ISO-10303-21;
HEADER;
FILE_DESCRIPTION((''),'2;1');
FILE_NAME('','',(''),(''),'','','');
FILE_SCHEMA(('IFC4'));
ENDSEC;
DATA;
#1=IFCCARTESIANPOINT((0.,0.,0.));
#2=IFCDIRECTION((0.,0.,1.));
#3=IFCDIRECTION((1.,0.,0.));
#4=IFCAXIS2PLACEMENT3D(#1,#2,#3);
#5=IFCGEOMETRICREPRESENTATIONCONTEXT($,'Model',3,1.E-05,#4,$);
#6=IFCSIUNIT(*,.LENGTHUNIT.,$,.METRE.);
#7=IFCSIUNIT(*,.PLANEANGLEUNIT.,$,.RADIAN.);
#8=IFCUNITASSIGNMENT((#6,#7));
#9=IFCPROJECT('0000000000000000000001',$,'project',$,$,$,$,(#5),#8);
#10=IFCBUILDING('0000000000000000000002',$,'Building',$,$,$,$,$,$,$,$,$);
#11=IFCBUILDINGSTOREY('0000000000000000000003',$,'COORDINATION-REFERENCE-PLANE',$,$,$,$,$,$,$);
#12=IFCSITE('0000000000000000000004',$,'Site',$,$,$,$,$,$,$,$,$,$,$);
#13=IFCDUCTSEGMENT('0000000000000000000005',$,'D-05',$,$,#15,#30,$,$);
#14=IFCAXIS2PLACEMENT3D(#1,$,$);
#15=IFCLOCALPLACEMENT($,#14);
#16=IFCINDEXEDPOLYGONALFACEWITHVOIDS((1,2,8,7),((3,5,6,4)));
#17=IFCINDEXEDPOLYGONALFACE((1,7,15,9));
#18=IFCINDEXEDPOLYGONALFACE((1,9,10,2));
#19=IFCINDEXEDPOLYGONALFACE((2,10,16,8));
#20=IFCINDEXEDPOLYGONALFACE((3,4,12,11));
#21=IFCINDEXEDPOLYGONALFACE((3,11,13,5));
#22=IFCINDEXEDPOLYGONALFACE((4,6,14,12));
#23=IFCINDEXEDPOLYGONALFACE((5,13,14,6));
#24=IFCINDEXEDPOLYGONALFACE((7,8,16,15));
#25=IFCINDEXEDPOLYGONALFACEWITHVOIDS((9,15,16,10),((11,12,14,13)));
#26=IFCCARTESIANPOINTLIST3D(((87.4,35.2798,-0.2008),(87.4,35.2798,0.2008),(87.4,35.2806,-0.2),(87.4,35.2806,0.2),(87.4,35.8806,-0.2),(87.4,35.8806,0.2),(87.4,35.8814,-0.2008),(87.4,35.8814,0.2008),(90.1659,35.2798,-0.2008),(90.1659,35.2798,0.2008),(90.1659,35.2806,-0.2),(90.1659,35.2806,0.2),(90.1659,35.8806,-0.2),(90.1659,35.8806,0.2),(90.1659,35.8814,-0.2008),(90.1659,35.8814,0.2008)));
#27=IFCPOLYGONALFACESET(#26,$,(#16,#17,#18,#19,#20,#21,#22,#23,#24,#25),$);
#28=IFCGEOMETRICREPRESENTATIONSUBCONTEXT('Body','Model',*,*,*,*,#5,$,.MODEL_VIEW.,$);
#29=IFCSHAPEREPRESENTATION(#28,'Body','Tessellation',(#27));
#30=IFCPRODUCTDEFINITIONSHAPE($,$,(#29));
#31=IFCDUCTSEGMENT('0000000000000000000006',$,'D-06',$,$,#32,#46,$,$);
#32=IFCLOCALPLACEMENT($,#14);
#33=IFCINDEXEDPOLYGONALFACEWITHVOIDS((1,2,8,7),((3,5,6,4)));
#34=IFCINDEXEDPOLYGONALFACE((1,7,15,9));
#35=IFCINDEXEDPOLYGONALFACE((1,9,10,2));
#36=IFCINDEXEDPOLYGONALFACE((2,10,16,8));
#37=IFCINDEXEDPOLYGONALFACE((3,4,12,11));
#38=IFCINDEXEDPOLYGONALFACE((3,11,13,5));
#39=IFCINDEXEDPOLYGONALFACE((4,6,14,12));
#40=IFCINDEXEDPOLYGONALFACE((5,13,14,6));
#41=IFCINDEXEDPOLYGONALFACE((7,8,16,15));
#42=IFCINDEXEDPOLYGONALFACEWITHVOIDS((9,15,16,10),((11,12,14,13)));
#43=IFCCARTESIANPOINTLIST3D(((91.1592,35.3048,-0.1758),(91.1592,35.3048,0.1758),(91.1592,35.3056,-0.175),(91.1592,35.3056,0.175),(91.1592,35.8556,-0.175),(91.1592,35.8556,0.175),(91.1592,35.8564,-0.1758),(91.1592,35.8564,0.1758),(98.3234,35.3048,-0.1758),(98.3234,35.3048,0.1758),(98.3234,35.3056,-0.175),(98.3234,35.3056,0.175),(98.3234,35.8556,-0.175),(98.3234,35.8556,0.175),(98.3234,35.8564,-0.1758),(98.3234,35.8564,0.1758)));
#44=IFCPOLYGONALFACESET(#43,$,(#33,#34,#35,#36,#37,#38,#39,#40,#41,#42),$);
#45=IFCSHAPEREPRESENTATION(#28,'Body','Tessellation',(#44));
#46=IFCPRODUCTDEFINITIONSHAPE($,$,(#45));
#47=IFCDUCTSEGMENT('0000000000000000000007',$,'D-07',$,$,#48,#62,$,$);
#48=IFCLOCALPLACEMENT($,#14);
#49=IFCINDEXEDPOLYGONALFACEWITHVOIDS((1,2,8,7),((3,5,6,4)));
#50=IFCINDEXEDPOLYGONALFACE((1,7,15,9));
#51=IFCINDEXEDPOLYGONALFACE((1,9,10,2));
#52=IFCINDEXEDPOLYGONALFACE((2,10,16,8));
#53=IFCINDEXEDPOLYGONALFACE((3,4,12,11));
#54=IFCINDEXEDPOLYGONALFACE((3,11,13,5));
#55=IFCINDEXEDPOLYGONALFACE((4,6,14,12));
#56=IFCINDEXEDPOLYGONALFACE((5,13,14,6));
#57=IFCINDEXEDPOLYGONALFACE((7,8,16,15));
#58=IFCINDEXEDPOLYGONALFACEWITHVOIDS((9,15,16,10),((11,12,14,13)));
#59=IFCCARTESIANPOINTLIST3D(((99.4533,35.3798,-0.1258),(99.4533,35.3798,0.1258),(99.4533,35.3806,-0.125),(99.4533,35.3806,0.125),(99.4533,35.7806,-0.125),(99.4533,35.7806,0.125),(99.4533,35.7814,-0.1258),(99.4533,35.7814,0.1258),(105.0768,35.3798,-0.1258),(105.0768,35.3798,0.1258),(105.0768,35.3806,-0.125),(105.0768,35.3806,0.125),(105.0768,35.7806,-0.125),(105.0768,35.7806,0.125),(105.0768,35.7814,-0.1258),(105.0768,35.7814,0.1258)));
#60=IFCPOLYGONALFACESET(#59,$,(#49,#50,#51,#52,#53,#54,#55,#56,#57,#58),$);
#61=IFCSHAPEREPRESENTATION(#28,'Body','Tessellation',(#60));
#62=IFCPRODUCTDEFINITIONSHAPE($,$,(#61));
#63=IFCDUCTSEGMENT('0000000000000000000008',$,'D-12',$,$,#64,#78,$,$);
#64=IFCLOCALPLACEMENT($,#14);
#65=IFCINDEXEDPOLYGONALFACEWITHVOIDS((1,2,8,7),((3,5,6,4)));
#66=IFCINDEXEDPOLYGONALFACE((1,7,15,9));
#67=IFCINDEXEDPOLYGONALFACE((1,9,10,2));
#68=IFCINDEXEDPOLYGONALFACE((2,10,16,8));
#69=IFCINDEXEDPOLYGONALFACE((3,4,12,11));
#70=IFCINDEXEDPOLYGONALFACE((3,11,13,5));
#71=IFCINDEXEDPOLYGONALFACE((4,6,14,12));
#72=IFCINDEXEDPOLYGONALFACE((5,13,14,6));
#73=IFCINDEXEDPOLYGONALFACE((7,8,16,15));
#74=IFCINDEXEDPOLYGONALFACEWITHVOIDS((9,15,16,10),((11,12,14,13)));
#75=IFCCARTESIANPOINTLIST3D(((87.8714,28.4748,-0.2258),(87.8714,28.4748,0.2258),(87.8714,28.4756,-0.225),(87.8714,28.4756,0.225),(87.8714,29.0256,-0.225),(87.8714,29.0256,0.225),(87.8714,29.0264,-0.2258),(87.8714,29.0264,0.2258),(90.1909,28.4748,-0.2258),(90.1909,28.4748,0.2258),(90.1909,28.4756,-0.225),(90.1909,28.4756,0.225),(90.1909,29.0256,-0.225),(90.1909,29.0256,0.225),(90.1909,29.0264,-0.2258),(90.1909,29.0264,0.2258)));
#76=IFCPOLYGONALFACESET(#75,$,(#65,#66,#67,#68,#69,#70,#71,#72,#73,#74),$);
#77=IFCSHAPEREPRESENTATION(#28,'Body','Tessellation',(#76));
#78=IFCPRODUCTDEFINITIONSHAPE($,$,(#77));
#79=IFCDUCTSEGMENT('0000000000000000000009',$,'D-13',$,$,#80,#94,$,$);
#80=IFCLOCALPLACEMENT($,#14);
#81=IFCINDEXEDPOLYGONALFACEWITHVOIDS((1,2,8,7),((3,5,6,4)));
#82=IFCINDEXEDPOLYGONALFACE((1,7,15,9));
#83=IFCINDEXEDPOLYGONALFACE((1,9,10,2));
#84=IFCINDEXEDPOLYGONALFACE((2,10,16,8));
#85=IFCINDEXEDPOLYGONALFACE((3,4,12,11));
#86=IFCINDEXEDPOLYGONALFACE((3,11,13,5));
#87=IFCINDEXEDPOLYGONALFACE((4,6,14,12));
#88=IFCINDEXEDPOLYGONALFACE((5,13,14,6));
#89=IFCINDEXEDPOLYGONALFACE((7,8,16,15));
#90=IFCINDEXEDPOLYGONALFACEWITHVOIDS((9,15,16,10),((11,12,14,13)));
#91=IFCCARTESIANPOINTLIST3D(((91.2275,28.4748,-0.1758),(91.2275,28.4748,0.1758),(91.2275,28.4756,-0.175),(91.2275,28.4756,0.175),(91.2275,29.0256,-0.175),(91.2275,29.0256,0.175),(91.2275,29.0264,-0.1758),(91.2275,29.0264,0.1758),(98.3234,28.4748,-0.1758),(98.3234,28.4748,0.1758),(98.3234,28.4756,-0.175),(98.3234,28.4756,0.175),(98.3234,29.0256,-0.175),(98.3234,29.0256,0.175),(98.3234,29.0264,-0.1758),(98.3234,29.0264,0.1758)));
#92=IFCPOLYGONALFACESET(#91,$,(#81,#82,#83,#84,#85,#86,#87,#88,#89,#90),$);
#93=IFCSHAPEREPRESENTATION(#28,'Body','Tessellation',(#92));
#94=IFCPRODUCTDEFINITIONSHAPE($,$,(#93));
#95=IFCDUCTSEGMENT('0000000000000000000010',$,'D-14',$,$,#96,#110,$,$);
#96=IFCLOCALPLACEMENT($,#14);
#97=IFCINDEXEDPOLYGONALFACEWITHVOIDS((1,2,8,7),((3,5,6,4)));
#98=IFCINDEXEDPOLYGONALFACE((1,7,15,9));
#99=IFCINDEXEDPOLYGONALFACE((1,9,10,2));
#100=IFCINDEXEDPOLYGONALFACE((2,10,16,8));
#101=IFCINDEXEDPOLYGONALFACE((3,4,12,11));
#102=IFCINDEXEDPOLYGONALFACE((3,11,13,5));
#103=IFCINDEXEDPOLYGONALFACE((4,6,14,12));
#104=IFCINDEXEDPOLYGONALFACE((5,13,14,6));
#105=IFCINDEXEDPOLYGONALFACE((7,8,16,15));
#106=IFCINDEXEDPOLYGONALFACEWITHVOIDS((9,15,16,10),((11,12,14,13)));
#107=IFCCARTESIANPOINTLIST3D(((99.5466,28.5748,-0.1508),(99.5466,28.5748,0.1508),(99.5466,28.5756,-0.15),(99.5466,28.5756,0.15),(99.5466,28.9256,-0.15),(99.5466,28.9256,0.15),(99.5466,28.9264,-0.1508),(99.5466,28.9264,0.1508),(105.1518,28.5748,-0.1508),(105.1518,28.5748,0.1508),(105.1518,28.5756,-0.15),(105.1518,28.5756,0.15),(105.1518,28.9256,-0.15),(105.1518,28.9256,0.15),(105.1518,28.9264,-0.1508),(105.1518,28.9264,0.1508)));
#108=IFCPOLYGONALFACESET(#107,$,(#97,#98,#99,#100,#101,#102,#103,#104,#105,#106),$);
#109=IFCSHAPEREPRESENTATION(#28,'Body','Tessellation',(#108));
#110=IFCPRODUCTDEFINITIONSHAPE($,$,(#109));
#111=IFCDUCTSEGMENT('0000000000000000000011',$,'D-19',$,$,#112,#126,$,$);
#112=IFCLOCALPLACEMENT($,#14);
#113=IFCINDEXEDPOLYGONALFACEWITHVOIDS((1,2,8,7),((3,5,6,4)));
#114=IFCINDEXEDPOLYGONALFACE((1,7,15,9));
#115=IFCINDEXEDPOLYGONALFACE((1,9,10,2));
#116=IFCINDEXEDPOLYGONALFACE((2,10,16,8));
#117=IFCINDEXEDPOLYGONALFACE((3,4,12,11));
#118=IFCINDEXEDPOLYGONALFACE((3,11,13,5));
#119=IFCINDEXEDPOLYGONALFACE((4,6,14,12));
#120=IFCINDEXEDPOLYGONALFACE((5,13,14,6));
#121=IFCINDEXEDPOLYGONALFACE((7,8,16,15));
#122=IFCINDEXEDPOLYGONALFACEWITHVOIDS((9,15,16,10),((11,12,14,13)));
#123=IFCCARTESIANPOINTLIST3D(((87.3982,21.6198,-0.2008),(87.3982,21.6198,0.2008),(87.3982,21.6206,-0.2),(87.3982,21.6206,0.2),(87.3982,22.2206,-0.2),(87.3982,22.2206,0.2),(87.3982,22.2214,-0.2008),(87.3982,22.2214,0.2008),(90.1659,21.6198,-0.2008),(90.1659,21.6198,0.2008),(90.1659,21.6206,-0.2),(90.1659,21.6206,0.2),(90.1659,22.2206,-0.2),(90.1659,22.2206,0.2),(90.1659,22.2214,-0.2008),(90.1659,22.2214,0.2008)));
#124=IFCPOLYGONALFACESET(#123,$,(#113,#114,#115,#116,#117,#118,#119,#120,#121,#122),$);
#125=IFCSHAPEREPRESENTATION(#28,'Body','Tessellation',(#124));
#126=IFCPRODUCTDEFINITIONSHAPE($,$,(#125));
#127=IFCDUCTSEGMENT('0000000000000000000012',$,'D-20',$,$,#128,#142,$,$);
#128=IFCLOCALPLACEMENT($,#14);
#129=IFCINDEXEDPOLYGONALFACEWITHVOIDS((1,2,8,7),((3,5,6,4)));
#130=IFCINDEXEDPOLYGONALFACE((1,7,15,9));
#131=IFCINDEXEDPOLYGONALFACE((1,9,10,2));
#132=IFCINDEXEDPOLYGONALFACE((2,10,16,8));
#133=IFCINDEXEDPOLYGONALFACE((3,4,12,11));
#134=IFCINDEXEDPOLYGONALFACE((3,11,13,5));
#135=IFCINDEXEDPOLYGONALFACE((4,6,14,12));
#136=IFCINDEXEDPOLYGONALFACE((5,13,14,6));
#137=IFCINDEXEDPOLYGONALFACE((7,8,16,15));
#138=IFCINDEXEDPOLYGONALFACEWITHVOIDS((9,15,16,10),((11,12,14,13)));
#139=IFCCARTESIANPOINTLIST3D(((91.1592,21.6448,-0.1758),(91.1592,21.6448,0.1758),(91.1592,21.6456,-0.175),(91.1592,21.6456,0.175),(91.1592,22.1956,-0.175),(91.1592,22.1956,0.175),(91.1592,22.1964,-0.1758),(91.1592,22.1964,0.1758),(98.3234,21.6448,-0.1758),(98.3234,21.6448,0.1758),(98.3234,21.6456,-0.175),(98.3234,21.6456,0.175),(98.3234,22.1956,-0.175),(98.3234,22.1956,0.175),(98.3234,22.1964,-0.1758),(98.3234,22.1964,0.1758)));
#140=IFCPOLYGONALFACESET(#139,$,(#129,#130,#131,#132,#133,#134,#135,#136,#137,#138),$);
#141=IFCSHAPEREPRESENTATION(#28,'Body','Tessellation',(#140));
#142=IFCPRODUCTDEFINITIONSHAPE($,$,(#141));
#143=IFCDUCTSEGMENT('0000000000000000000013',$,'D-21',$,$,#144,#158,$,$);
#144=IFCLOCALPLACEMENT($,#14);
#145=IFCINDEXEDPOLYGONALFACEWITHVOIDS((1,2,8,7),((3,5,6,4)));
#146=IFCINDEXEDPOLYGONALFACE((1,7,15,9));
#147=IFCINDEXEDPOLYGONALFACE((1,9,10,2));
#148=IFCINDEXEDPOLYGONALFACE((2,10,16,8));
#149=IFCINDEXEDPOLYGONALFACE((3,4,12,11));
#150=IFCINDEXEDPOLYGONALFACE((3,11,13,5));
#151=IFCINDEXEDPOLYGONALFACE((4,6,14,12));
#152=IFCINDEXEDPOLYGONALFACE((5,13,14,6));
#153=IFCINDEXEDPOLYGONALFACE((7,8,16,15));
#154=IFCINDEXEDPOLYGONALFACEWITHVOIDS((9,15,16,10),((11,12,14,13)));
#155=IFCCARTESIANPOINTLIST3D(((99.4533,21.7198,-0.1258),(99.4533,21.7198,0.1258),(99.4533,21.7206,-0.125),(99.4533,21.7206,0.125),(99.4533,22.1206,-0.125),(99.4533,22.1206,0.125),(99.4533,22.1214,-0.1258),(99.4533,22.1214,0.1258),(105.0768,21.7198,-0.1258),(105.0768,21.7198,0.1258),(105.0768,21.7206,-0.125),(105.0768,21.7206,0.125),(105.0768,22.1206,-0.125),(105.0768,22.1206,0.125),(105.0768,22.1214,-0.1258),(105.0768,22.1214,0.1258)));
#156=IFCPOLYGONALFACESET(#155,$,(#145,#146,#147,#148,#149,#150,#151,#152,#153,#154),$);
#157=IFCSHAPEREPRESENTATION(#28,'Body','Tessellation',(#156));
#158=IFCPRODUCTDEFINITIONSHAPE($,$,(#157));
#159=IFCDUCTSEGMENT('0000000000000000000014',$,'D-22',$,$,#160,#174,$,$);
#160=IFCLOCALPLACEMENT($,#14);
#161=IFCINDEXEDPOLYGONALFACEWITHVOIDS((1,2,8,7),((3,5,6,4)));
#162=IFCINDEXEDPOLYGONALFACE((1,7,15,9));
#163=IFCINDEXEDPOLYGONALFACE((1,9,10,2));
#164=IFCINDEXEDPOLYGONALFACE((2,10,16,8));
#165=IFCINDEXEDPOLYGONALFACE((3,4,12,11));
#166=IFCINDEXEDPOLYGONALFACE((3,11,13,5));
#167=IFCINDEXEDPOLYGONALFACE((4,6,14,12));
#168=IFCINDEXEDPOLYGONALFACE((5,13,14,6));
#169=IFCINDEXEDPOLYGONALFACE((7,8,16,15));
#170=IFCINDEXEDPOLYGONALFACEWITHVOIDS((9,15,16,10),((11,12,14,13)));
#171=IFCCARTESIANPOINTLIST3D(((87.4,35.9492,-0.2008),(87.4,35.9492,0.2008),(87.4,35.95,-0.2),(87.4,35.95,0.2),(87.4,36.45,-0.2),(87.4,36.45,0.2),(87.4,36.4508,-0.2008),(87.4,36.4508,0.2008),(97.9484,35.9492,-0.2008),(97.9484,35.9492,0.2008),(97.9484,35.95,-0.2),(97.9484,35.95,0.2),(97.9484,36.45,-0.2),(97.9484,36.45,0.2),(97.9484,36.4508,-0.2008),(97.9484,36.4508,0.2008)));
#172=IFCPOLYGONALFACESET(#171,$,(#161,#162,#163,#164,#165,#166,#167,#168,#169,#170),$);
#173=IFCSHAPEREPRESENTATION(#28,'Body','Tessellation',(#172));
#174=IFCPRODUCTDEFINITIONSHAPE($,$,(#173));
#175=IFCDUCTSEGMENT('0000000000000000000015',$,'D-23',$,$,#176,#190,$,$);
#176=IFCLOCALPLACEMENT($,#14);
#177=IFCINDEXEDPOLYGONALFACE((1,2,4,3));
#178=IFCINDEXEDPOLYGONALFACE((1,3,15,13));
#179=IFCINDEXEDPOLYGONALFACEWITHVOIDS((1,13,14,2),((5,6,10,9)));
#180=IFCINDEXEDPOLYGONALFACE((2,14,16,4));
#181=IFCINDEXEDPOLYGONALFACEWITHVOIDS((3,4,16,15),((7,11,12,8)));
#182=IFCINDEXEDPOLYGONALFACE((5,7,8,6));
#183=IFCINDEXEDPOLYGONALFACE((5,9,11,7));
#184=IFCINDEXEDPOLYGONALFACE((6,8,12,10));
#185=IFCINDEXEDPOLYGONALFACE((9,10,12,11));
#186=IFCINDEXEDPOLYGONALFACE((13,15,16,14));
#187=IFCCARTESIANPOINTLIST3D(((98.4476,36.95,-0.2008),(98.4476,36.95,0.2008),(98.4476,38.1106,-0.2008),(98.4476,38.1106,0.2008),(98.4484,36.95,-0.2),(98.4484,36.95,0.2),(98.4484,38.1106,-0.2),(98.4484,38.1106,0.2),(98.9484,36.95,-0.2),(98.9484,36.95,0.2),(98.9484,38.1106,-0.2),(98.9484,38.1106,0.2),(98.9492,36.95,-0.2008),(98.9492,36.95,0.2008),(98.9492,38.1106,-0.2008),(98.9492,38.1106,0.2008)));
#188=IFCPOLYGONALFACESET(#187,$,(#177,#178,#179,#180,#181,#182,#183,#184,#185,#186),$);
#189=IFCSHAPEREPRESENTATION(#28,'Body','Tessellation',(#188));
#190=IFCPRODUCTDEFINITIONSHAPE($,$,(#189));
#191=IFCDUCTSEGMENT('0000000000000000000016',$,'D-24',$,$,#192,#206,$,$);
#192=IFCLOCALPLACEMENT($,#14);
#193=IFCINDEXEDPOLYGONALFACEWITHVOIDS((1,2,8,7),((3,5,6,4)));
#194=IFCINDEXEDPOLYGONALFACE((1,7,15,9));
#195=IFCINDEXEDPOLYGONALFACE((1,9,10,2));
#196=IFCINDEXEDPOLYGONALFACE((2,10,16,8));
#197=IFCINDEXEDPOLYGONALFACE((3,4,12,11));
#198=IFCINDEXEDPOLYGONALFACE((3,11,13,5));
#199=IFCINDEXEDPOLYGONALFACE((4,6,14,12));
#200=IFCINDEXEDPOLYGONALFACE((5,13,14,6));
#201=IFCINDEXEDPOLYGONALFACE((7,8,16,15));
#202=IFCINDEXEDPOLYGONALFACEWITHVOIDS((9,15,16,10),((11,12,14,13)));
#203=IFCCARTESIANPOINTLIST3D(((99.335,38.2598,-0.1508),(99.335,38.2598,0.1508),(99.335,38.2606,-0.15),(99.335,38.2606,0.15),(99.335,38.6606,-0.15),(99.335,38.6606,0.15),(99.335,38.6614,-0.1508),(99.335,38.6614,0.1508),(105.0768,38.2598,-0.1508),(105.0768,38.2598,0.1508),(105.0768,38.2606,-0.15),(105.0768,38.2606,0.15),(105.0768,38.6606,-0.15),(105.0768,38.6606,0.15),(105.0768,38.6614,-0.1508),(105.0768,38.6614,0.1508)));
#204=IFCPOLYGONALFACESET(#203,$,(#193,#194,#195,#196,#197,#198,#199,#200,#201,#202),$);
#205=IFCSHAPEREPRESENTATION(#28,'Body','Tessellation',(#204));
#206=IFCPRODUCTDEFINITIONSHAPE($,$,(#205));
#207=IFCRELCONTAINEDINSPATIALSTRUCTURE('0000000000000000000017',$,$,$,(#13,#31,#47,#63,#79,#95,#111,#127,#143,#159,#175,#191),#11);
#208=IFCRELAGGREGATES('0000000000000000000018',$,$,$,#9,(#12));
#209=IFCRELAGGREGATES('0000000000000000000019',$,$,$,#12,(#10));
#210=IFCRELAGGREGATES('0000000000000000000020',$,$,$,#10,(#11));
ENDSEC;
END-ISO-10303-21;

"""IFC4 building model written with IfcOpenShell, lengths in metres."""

from ifc_helpers import new_model, si_unit, frame, origin, origin_with_axes, place, context, subcontext, project, spatial, hollow_rectangle, extrude, element, save


model = new_model("IFC4")

# Units and contexts
model_context = context("Model", 3, precision=1e-05, world=origin_with_axes())
body_context = subcontext(model_context, "Body", "Model", "MODEL_VIEW")
ifc_project = project(units=[si_unit("LENGTHUNIT", "METRE"), si_unit("PLANEANGLEUNIT", "RADIAN")], contexts=[model_context])

# Site, building, storey
site = spatial("IfcSite", under=ifc_project, Name="Site")
building = spatial("IfcBuilding", under=site, Name="Building")
storey = spatial("IfcBuildingStorey", under=building, Name="COORDINATION-REFERENCE-PLANE")

# Duct segments
duct_segment_1_placement = place(None, frame((87.4, 35.5806, 0.0), z_axis=(1.0, 0.0, 0.0), x_axis=(0.0, 1.0, 0.0)))
element("IfcDuctSegment", 1, at=duct_segment_1_placement, inside=storey, Name="D-05", context=body_context, shape_type="SweptSolid", body=[
    extrude(hollow_rectangle(XDim=0.6016, YDim=0.4016, WallThickness=0.0008), origin(), (0.0, 0.0, 1.0), 2.7659),
])
duct_segment_2_placement = place(None, frame((91.1592, 35.5806, 0.0), z_axis=(1.0, 0.0, 0.0), x_axis=(0.0, 1.0, 0.0)))
element("IfcDuctSegment", 2, at=duct_segment_2_placement, inside=storey, Name="D-06", context=body_context, shape_type="SweptSolid", body=[
    extrude(hollow_rectangle(XDim=0.5516, YDim=0.3516, WallThickness=0.0008), origin(), (0.0, 0.0, 1.0), 7.1642),
])
duct_segment_3_placement = place(None, frame((99.4533, 35.5806, 0.0), z_axis=(1.0, 0.0, 0.0), x_axis=(0.0, 1.0, 0.0)))
element("IfcDuctSegment", 3, at=duct_segment_3_placement, inside=storey, Name="D-07", context=body_context, shape_type="SweptSolid", body=[
    extrude(hollow_rectangle(XDim=0.4016, YDim=0.2516, WallThickness=0.0008), origin(), (0.0, 0.0, 1.0), 5.6234),
])
duct_segment_4_placement = place(None, frame((87.8714, 28.7506, 0.0), z_axis=(1.0, 0.0, 0.0), x_axis=(0.0, 1.0, 0.0)))
element("IfcDuctSegment", 4, at=duct_segment_4_placement, inside=storey, Name="D-12", context=body_context, shape_type="SweptSolid", body=[
    extrude(hollow_rectangle(XDim=0.5516, YDim=0.4516, WallThickness=0.0008), origin(), (0.0, 0.0, 1.0), 2.3195),
])
duct_segment_5_placement = place(None, frame((91.2275, 28.7506, 0.0), z_axis=(1.0, 0.0, 0.0), x_axis=(0.0, 1.0, 0.0)))
element("IfcDuctSegment", 5, at=duct_segment_5_placement, inside=storey, Name="D-13", context=body_context, shape_type="SweptSolid", body=[
    extrude(hollow_rectangle(XDim=0.5516, YDim=0.3516, WallThickness=0.0008), origin(), (0.0, 0.0, 1.0), 7.0959),
])
duct_segment_6_placement = place(None, frame((99.5466, 28.7506, 0.0), z_axis=(1.0, 0.0, 0.0), x_axis=(0.0, 1.0, 0.0)))
element("IfcDuctSegment", 6, at=duct_segment_6_placement, inside=storey, Name="D-14", context=body_context, shape_type="SweptSolid", body=[
    extrude(hollow_rectangle(XDim=0.3516, YDim=0.3016, WallThickness=0.0008), origin(), (0.0, 0.0, 1.0), 5.6051),
])
duct_segment_7_placement = place(None, frame((87.3982, 21.9206, 0.0), z_axis=(1.0, 0.0, 0.0), x_axis=(0.0, 1.0, 0.0)))
element("IfcDuctSegment", 7, at=duct_segment_7_placement, inside=storey, Name="D-19", context=body_context, shape_type="SweptSolid", body=[
    extrude(hollow_rectangle(XDim=0.6016, YDim=0.4016, WallThickness=0.0008), origin(), (0.0, 0.0, 1.0), 2.7677),
])
duct_segment_8_placement = place(None, frame((91.1592, 21.9206, 0.0), z_axis=(1.0, 0.0, 0.0), x_axis=(0.0, 1.0, 0.0)))
element("IfcDuctSegment", 8, at=duct_segment_8_placement, inside=storey, Name="D-20", context=body_context, shape_type="SweptSolid", body=[
    extrude(hollow_rectangle(XDim=0.5516, YDim=0.3516, WallThickness=0.0008), origin(), (0.0, 0.0, 1.0), 7.1642),
])
duct_segment_9_placement = place(None, frame((99.4533, 21.9206, 0.0), z_axis=(1.0, 0.0, 0.0), x_axis=(0.0, 1.0, 0.0)))
element("IfcDuctSegment", 9, at=duct_segment_9_placement, inside=storey, Name="D-21", context=body_context, shape_type="SweptSolid", body=[
    extrude(hollow_rectangle(XDim=0.4016, YDim=0.2516, WallThickness=0.0008), origin(), (0.0, 0.0, 1.0), 5.6234),
])
duct_segment_10_placement = place(None, frame((87.4, 36.2, 0.0), z_axis=(1.0, 0.0, 0.0), x_axis=(0.0, 1.0, 0.0)))
element("IfcDuctSegment", 10, at=duct_segment_10_placement, inside=storey, Name="D-22", context=body_context, shape_type="SweptSolid", body=[
    extrude(hollow_rectangle(XDim=0.5016, YDim=0.4016, WallThickness=0.0008), origin(), (0.0, 0.0, 1.0), 10.5484),
])
duct_segment_11_placement = place(None, frame((98.6984, 36.95, 0.0), z_axis=(0.0, 1.0, 0.0), x_axis=(1.0, 0.0, 0.0)))
element("IfcDuctSegment", 11, at=duct_segment_11_placement, inside=storey, Name="D-23", context=body_context, shape_type="SweptSolid", body=[
    extrude(hollow_rectangle(XDim=0.5016, YDim=0.4016, WallThickness=0.0008), origin(), (0.0, 0.0, 1.0), 1.1606),
])
duct_segment_12_placement = place(None, frame((99.335, 38.4606, 0.0), z_axis=(1.0, 0.0, 0.0), x_axis=(0.0, 1.0, 0.0)))
element("IfcDuctSegment", 12, at=duct_segment_12_placement, inside=storey, Name="D-24", context=body_context, shape_type="SweptSolid", body=[
    extrude(hollow_rectangle(XDim=0.4016, YDim=0.3016, WallThickness=0.0008), origin(), (0.0, 0.0, 1.0), 5.7417),
])

save(model, "model.ifc")
